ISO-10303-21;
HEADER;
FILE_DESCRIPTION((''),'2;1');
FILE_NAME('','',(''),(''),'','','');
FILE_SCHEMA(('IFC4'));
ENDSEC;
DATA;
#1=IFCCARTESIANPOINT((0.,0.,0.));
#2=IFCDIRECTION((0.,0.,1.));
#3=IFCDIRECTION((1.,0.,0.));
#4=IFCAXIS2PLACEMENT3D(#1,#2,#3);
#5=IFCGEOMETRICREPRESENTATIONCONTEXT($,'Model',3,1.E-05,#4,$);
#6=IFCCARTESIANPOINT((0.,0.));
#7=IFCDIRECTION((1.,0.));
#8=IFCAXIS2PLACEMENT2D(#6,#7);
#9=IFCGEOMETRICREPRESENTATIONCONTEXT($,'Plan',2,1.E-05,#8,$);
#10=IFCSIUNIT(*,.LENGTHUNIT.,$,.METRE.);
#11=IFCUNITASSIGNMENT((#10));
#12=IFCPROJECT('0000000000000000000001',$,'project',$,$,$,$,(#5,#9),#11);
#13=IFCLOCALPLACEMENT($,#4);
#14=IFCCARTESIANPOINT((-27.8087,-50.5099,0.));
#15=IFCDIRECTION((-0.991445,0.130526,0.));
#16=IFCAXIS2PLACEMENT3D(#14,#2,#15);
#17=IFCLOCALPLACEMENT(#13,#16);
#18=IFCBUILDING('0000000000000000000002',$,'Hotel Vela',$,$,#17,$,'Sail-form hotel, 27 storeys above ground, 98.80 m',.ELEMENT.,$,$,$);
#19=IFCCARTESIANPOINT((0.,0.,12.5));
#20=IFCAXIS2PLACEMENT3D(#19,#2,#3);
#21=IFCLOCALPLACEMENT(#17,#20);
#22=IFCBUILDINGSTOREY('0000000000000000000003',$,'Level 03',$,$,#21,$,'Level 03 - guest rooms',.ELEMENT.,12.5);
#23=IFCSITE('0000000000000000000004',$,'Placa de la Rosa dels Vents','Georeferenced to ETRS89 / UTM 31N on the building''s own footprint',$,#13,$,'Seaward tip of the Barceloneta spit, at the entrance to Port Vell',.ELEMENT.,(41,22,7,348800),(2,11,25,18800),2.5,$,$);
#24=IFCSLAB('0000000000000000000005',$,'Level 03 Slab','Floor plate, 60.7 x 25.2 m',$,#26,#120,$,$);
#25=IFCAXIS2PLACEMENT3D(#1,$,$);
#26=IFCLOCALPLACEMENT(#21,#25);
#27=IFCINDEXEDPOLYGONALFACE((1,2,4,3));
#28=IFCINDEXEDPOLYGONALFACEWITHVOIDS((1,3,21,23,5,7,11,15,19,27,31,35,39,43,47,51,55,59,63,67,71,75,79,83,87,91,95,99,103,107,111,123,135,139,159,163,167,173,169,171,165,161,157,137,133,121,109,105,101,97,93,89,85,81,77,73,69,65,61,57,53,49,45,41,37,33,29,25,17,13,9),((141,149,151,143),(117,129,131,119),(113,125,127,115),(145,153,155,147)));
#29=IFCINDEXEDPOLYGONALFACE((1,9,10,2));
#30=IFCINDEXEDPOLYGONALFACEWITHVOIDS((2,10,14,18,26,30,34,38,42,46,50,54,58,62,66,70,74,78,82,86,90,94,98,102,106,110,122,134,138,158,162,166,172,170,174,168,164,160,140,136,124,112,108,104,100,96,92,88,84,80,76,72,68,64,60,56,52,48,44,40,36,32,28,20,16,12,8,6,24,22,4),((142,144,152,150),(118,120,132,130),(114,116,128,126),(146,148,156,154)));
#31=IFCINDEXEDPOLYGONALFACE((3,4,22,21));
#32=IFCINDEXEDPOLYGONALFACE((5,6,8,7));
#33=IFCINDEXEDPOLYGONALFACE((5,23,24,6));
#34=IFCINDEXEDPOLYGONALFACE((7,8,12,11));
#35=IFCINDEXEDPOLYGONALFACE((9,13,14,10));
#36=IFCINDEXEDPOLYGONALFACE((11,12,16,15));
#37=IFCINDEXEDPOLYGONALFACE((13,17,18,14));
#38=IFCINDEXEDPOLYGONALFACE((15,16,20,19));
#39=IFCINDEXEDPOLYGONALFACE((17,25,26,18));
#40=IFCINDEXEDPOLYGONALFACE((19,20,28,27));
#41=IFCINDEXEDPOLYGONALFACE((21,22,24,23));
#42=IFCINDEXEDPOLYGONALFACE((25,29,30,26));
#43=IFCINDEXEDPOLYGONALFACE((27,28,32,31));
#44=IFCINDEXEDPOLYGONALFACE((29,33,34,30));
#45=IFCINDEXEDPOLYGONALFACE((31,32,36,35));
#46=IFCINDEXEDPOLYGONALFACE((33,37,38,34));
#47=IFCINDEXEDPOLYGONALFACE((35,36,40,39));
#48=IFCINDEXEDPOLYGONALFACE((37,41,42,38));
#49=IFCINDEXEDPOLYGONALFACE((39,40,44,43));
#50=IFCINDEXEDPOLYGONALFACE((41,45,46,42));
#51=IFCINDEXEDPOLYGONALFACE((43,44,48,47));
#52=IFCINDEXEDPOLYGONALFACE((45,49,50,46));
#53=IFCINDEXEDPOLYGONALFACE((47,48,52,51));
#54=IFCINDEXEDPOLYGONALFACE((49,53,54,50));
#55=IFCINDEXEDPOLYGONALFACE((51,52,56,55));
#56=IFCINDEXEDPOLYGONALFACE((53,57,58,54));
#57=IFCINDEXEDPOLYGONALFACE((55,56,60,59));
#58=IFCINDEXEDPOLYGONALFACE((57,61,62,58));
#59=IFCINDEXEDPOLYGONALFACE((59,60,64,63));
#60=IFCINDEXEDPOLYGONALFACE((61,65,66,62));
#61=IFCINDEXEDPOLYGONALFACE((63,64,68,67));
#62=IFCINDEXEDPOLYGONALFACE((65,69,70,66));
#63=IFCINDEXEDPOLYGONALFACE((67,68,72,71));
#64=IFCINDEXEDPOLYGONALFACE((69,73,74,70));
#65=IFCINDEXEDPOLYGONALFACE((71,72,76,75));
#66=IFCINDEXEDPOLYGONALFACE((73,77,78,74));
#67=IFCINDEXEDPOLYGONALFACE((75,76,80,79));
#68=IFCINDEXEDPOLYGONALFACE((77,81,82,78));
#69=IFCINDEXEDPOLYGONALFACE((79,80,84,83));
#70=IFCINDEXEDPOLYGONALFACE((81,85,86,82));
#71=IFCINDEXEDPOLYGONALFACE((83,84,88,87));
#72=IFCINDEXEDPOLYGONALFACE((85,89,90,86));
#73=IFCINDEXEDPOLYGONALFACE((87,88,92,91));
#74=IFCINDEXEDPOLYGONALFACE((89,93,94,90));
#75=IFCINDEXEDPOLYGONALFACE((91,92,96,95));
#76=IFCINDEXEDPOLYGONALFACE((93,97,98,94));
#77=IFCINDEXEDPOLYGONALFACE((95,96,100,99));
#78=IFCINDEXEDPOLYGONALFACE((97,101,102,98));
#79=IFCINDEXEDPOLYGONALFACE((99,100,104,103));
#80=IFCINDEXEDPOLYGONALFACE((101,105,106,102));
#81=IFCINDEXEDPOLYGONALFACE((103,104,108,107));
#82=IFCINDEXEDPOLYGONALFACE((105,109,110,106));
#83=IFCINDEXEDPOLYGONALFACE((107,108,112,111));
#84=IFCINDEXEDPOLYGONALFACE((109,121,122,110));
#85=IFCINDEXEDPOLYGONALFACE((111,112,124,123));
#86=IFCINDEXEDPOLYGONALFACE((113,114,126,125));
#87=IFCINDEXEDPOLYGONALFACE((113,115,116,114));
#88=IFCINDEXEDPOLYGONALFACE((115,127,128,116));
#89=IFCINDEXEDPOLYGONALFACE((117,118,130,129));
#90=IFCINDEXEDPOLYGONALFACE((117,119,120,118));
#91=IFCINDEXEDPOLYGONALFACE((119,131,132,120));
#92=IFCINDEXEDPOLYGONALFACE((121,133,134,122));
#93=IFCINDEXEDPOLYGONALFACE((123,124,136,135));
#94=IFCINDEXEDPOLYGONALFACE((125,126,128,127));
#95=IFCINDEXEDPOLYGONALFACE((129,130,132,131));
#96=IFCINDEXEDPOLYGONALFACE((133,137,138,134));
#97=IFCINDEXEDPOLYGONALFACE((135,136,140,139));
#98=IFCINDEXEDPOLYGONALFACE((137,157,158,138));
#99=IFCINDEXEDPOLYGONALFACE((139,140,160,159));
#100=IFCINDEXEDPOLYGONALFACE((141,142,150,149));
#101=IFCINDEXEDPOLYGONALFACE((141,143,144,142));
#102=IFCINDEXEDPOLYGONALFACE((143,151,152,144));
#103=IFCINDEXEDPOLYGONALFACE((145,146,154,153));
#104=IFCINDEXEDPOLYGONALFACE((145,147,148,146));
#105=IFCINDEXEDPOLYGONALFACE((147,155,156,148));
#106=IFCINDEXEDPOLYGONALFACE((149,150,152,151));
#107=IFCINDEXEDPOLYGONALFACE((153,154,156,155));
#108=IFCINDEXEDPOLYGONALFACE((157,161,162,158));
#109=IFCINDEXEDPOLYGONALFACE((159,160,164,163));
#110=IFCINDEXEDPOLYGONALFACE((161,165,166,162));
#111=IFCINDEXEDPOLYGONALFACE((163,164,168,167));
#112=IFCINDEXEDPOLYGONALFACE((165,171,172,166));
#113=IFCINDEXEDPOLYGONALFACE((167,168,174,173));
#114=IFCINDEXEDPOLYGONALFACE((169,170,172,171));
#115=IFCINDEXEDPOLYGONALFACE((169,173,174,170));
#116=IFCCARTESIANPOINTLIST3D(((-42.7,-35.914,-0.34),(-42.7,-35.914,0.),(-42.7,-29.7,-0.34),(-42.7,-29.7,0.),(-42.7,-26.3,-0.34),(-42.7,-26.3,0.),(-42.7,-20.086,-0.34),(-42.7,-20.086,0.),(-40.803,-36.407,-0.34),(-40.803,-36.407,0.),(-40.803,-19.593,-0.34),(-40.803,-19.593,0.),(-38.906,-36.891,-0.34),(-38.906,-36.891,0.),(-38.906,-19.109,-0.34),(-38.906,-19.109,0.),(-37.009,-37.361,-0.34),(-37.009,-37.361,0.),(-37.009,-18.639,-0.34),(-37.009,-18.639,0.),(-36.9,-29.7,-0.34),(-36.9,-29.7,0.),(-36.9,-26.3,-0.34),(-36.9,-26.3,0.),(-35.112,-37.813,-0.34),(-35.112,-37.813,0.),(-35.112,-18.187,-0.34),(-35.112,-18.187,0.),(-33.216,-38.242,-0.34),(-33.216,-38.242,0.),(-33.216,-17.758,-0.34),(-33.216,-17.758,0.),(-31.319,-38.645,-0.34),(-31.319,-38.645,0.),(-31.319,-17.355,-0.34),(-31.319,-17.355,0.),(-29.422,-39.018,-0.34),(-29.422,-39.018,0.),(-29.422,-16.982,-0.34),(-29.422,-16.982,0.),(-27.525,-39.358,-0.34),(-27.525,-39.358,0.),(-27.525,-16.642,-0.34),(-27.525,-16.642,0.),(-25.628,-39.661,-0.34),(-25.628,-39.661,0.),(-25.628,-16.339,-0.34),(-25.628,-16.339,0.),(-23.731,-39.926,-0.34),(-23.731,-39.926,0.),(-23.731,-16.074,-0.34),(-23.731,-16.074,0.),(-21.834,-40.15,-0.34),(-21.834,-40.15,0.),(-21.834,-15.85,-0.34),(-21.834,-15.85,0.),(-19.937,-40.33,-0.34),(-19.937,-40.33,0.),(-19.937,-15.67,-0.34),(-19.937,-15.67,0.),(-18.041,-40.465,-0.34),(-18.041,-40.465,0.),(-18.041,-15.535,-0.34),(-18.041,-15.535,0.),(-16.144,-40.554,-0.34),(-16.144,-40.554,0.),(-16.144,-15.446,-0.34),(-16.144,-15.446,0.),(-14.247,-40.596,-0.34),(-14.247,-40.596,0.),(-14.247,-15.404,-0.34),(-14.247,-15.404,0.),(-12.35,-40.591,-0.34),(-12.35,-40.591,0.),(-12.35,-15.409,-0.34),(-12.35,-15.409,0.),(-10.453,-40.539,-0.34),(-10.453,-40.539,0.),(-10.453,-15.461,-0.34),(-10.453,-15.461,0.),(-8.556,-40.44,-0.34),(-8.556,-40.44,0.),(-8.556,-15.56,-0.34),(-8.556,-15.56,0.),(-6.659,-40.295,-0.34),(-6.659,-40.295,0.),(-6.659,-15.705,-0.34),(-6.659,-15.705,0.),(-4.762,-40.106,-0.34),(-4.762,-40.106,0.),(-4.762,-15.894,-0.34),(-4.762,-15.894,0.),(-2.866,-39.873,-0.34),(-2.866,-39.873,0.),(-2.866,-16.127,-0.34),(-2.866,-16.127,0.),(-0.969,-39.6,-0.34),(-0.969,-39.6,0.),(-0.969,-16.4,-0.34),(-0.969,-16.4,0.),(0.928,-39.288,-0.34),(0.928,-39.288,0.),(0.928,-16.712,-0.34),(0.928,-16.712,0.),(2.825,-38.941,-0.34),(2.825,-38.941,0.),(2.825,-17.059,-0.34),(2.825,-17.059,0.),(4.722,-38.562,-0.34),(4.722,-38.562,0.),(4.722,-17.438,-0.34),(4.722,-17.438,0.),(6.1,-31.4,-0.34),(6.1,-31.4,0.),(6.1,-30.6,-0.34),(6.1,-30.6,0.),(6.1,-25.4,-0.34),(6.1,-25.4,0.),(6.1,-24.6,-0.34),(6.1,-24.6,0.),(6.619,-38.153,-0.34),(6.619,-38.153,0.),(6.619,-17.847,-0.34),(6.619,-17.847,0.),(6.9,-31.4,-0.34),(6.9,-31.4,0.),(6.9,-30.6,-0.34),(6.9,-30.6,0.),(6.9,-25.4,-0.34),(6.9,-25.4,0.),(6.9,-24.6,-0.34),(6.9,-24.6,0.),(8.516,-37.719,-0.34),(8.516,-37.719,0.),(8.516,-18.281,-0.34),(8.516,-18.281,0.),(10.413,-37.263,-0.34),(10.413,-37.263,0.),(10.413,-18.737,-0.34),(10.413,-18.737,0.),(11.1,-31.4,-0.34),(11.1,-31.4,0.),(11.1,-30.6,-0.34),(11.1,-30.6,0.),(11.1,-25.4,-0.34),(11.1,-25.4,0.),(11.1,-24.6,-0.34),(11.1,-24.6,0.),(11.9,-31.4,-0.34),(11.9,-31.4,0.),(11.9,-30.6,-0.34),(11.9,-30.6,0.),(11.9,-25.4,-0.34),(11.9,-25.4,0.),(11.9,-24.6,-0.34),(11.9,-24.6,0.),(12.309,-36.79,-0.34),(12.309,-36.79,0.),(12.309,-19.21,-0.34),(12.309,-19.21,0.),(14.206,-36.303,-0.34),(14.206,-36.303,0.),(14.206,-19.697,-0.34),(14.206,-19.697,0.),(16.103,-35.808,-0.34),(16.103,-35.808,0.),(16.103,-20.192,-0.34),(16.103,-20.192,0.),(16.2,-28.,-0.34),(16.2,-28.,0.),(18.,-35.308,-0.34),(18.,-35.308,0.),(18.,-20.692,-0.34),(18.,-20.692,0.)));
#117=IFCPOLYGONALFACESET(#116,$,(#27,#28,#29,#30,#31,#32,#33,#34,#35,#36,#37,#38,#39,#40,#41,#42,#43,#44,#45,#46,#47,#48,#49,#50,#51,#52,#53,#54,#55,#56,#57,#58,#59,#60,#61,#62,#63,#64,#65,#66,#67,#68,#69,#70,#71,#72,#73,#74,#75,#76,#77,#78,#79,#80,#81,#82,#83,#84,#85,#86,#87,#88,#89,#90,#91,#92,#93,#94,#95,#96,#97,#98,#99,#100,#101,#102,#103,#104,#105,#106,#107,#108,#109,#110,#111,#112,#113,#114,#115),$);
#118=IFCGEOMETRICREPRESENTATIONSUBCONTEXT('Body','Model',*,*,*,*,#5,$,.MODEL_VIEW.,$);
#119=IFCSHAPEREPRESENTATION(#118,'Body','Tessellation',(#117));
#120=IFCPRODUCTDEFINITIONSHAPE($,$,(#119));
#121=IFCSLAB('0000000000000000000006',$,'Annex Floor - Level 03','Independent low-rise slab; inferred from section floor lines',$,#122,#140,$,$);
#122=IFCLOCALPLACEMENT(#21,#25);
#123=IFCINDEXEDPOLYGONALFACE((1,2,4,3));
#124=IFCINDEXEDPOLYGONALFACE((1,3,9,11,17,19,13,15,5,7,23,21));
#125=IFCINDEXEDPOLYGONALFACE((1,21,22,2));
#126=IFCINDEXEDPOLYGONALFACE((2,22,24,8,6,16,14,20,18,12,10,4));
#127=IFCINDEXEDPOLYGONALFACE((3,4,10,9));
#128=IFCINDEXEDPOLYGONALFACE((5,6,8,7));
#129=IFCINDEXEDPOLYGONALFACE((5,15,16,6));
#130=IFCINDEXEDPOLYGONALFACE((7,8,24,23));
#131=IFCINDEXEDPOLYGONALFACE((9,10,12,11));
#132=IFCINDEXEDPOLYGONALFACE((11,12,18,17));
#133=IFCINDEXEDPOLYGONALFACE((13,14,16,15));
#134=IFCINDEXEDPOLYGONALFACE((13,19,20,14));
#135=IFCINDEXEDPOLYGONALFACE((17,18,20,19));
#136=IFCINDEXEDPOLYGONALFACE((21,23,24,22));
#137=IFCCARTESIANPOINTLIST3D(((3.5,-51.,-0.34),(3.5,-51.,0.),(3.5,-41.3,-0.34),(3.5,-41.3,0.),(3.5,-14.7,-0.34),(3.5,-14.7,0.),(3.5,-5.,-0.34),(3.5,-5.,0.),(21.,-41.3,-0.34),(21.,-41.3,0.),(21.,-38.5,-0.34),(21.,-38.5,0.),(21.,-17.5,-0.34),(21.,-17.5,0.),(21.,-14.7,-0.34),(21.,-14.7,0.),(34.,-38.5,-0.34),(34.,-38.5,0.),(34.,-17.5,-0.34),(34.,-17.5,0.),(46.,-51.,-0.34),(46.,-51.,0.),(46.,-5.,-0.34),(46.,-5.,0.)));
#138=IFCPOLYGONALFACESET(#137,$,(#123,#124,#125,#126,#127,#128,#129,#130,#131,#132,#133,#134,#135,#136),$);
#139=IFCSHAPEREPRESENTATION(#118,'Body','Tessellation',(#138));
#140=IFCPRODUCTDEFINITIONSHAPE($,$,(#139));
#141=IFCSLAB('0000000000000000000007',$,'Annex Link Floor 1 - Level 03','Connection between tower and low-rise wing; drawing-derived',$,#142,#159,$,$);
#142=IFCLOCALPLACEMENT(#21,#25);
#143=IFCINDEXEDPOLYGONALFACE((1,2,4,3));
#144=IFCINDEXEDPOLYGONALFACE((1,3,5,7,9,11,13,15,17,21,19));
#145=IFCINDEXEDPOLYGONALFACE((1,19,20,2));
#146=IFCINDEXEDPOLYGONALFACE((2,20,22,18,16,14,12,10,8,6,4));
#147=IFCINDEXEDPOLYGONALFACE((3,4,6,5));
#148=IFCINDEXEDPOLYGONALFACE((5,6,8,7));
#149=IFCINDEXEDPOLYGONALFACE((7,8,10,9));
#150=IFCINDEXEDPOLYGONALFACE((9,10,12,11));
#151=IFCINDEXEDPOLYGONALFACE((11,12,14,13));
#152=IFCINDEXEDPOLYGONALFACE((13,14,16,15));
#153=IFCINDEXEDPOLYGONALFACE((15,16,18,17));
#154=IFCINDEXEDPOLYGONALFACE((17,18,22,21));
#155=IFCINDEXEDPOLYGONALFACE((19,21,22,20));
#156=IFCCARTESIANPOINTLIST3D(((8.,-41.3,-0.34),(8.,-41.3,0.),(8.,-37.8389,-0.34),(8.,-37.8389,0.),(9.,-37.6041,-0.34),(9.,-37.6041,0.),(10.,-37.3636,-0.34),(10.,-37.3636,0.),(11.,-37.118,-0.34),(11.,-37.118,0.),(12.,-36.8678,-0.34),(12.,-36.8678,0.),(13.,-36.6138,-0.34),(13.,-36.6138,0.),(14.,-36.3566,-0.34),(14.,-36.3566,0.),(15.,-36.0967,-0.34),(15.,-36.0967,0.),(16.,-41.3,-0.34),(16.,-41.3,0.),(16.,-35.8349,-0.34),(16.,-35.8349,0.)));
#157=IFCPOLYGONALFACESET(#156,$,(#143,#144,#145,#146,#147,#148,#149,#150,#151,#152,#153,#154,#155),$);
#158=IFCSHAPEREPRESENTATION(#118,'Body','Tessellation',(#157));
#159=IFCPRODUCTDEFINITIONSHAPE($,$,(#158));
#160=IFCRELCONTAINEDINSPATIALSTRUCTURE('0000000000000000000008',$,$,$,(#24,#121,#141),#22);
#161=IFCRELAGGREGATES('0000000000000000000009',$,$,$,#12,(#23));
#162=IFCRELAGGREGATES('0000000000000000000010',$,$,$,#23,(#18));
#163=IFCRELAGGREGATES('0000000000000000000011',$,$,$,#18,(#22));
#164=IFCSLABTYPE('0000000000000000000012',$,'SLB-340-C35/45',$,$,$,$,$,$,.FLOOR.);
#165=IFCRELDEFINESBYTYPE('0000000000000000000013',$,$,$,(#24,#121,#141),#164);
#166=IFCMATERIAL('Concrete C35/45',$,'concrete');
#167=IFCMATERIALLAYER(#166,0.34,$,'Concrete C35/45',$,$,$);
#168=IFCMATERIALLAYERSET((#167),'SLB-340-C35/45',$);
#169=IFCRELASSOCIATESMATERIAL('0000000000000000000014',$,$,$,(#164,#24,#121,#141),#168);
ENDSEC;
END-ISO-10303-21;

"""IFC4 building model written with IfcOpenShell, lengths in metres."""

from ifc_helpers import new_model, si_unit, frame, origin_with_axes, origin_2d_with_axis, place, context, subcontext, project, spatial, line, indexed_curve, outline, extrude, material, layer, layer_set, layer_usage, type_object, element, save


model = new_model("IFC4")

# Units and contexts
model_context = context("Model", 3, precision=1e-05, world=origin_with_axes())
plan_context = context("Plan", 2, precision=1e-05, world=origin_2d_with_axis())
body_context = subcontext(model_context, "Body", "Model", "MODEL_VIEW")
ifc_project = project(units=[si_unit("LENGTHUNIT", "METRE")], contexts=[model_context, plan_context])

# Site, building, storey
site_placement = place(None, origin_with_axes())
site = spatial("IfcSite", under=ifc_project, at=site_placement, Name="Placa de la Rosa dels Vents", Description="Georeferenced to ETRS89 / UTM 31N on the building's own footprint", LongName="Seaward tip of the Barceloneta spit, at the entrance to Port Vell", CompositionType="ELEMENT", RefLatitude=(41, 22, 7, 348800), RefLongitude=(2, 11, 25, 18800), RefElevation=2.5)
building_placement = place(site_placement, frame((-27.8087, -50.5099, 0.0), z_axis=(0.0, 0.0, 1.0), x_axis=(-0.991445, 0.130526, 0.0)))
building = spatial("IfcBuilding", under=site, at=building_placement, Name="Hotel Vela", LongName="Sail-form hotel, 27 storeys above ground, 98.80 m", CompositionType="ELEMENT")
storey_placement = place(building_placement, frame((0.0, 0.0, 12.5), z_axis=(0.0, 0.0, 1.0), x_axis=(1.0, 0.0, 0.0)))
storey = spatial("IfcBuildingStorey", under=building, at=storey_placement, Name="Level 03", LongName="Level 03 - guest rooms", CompositionType="ELEMENT", Elevation=12.5)

# Shared definitions
ifc_material = material(Name="Concrete C35/45", Category="concrete")

# Slab, openings
ifc_layer_1 = layer(ifc_material, 0.34, Name="Concrete C35/45")
ifc_layer_set_1 = layer_set([ifc_layer_1], Name="SLB-340-C35/45")
ifc_layer_usage_1 = layer_usage(ifc_layer_set_1, "AXIS3", "POSITIVE", 0.0)
slab_type = type_object("IfcSlabType", Name="SLB-340-C35/45", PredefinedType="FLOOR", material=ifc_layer_set_1)
slab_1_placement = place(storey_placement, frame((0.0, 0.0, -0.34), z_axis=(0.0, 0.0, 1.0), x_axis=(1.0, 0.0, 0.0)))
slab_1 = element("IfcSlab", 1, at=slab_1_placement, inside=storey, type_object=slab_type, material=ifc_layer_usage_1, Name="Level 03 Slab", Description="Floor plate, 60.7 x 25.2 m", context=body_context, shape_type="SweptSolid", body=[
    extrude(outline(indexed_curve([(-42.7, -35.914), (-40.803, -36.407), (-38.906, -36.891), (-37.009, -37.361), (-35.112, -37.813), (-33.216, -38.242), (-31.319, -38.645), (-29.422, -39.018), (-27.525, -39.358), (-25.628, -39.661), (-23.731, -39.926), (-21.834, -40.15), (-19.937, -40.33), (-18.041, -40.465), (-16.144, -40.554), (-14.247, -40.596), (-12.35, -40.591), (-10.453, -40.539), (-8.556, -40.44), (-6.659, -40.295), (-4.762, -40.106), (-2.866, -39.873), (-0.969, -39.6), (0.928, -39.288), (2.825, -38.941), (4.722, -38.562), (6.619, -38.153), (8.516, -37.719), (10.413, -37.263), (12.309, -36.79), (14.206, -36.303), (16.103, -35.808), (18.0, -35.308), (16.2, -28.0), (18.0, -20.692), (16.103, -20.192), (14.206, -19.697), (12.309, -19.21), (10.413, -18.737), (8.516, -18.281), (6.619, -17.847), (4.722, -17.438), (2.825, -17.059), (0.928, -16.712), (-0.969, -16.4), (-2.866, -16.127), (-4.762, -15.894), (-6.659, -15.705), (-8.556, -15.56), (-10.453, -15.461), (-12.35, -15.409), (-14.247, -15.404), (-16.144, -15.446), (-18.041, -15.535), (-19.937, -15.67), (-21.834, -15.85), (-23.731, -16.074), (-25.628, -16.339), (-27.525, -16.642), (-29.422, -16.982), (-31.319, -17.355), (-33.216, -17.758), (-35.112, -18.187), (-37.009, -18.639), (-38.906, -19.109), (-40.803, -19.593), (-42.7, -20.086), (-42.7, -26.3), (-36.9, -26.3), (-36.9, -29.7), (-42.7, -29.7)], segments=[line(1, 2, 3, 4, 5, 6, 7, 8, 9, 10, 11, 12, 13, 14, 15, 16, 17, 18, 19, 20, 21, 22, 23, 24, 25, 26, 27, 28, 29, 30, 31, 32, 33, 34, 35, 36, 37, 38, 39, 40, 41, 42, 43, 44, 45, 46, 47, 48, 49, 50, 51, 52, 53, 54, 55, 56, 57, 58, 59, 60, 61, 62, 63, 64, 65, 66, 67, 68, 69, 70, 71, 1)])), origin_with_axes(), (0.0, 0.0, 1.0), 0.34),
])
opening_1_placement = place(slab_1_placement, frame((6.1, -31.4, -0.05), z_axis=(0.0, 0.0, 1.0), x_axis=(1.0, 0.0, 0.0)))
element("IfcOpeningElement", 2, at=opening_1_placement, cuts=slab_1, PredefinedType="OPENING", context=body_context, shape_type="SweptSolid", body=[
    extrude(outline(indexed_curve([(0.0, 0.0), (0.8, 0.0), (0.8, 0.8), (0.0, 0.8)], segments=[line(1, 2, 3, 4, 1)])), origin_with_axes(), (0.0, 0.0, 1.0), 0.44),
])
opening_2_placement = place(slab_1_placement, frame((6.1, -25.4, -0.05), z_axis=(0.0, 0.0, 1.0), x_axis=(1.0, 0.0, 0.0)))
element("IfcOpeningElement", 3, at=opening_2_placement, cuts=slab_1, PredefinedType="OPENING", context=body_context, shape_type="SweptSolid", body=[
    extrude(outline(indexed_curve([(0.0, 0.0), (0.8, 0.0), (0.8, 0.8), (0.0, 0.8)], segments=[line(1, 2, 3, 4, 1)])), origin_with_axes(), (0.0, 0.0, 1.0), 0.44),
])
opening_3_placement = place(slab_1_placement, frame((11.1, -31.4, -0.05), z_axis=(0.0, 0.0, 1.0), x_axis=(1.0, 0.0, 0.0)))
element("IfcOpeningElement", 4, at=opening_3_placement, cuts=slab_1, PredefinedType="OPENING", context=body_context, shape_type="SweptSolid", body=[
    extrude(outline(indexed_curve([(0.0, 0.0), (0.8, 0.0), (0.8, 0.8), (0.0, 0.8)], segments=[line(1, 2, 3, 4, 1)])), origin_with_axes(), (0.0, 0.0, 1.0), 0.44),
])
opening_4_placement = place(slab_1_placement, frame((11.1, -25.4, -0.05), z_axis=(0.0, 0.0, 1.0), x_axis=(1.0, 0.0, 0.0)))
element("IfcOpeningElement", 5, at=opening_4_placement, cuts=slab_1, PredefinedType="OPENING", context=body_context, shape_type="SweptSolid", body=[
    extrude(outline(indexed_curve([(0.0, 0.0), (0.8, 0.0), (0.8, 0.8), (0.0, 0.8)], segments=[line(1, 2, 3, 4, 1)])), origin_with_axes(), (0.0, 0.0, 1.0), 0.44),
])

# Slabs
ifc_layer_usage_2 = layer_usage(ifc_layer_set_1, "AXIS3", "POSITIVE", 0.0)
slab_2_placement = place(storey_placement, frame((0.0, 0.0, -0.34), z_axis=(0.0, 0.0, 1.0), x_axis=(1.0, 0.0, 0.0)))
element("IfcSlab", 6, at=slab_2_placement, inside=storey, type_object=slab_type, material=ifc_layer_usage_2, Name="Annex Floor - Level 03", Description="Independent low-rise slab; inferred from section floor lines", context=body_context, shape_type="SweptSolid", body=[
    extrude(outline(indexed_curve([(3.5, -51.0), (46.0, -51.0), (46.0, -5.0), (3.5, -5.0), (3.5, -14.7), (21.0, -14.7), (21.0, -17.5), (34.0, -17.5), (34.0, -38.5), (21.0, -38.5), (21.0, -41.3), (3.5, -41.3)], segments=[line(1, 2, 3, 4, 5, 6, 7, 8, 9, 10, 11, 12, 1)])), origin_with_axes(), (0.0, 0.0, 1.0), 0.34),
])
ifc_layer_usage_3 = layer_usage(ifc_layer_set_1, "AXIS3", "POSITIVE", 0.0)
slab_3_placement = place(storey_placement, frame((0.0, 0.0, -0.34), z_axis=(0.0, 0.0, 1.0), x_axis=(1.0, 0.0, 0.0)))
element("IfcSlab", 7, at=slab_3_placement, inside=storey, type_object=slab_type, material=ifc_layer_usage_3, Name="Annex Link Floor 1 - Level 03", Description="Connection between tower and low-rise wing; drawing-derived", context=body_context, shape_type="SweptSolid", body=[
    extrude(outline(indexed_curve([(8.0, -41.3), (16.0, -41.3), (16.0, -35.8349), (15.0, -36.0967), (14.0, -36.3566), (13.0, -36.6138), (12.0, -36.8678), (11.0, -37.118), (10.0, -37.3636), (9.0, -37.6041), (8.0, -37.8389)], segments=[line(1, 2, 3, 4, 5, 6, 7, 8, 9, 10, 11, 1)])), origin_with_axes(), (0.0, 0.0, 1.0), 0.34),
])

save(model, "model.ifc")
